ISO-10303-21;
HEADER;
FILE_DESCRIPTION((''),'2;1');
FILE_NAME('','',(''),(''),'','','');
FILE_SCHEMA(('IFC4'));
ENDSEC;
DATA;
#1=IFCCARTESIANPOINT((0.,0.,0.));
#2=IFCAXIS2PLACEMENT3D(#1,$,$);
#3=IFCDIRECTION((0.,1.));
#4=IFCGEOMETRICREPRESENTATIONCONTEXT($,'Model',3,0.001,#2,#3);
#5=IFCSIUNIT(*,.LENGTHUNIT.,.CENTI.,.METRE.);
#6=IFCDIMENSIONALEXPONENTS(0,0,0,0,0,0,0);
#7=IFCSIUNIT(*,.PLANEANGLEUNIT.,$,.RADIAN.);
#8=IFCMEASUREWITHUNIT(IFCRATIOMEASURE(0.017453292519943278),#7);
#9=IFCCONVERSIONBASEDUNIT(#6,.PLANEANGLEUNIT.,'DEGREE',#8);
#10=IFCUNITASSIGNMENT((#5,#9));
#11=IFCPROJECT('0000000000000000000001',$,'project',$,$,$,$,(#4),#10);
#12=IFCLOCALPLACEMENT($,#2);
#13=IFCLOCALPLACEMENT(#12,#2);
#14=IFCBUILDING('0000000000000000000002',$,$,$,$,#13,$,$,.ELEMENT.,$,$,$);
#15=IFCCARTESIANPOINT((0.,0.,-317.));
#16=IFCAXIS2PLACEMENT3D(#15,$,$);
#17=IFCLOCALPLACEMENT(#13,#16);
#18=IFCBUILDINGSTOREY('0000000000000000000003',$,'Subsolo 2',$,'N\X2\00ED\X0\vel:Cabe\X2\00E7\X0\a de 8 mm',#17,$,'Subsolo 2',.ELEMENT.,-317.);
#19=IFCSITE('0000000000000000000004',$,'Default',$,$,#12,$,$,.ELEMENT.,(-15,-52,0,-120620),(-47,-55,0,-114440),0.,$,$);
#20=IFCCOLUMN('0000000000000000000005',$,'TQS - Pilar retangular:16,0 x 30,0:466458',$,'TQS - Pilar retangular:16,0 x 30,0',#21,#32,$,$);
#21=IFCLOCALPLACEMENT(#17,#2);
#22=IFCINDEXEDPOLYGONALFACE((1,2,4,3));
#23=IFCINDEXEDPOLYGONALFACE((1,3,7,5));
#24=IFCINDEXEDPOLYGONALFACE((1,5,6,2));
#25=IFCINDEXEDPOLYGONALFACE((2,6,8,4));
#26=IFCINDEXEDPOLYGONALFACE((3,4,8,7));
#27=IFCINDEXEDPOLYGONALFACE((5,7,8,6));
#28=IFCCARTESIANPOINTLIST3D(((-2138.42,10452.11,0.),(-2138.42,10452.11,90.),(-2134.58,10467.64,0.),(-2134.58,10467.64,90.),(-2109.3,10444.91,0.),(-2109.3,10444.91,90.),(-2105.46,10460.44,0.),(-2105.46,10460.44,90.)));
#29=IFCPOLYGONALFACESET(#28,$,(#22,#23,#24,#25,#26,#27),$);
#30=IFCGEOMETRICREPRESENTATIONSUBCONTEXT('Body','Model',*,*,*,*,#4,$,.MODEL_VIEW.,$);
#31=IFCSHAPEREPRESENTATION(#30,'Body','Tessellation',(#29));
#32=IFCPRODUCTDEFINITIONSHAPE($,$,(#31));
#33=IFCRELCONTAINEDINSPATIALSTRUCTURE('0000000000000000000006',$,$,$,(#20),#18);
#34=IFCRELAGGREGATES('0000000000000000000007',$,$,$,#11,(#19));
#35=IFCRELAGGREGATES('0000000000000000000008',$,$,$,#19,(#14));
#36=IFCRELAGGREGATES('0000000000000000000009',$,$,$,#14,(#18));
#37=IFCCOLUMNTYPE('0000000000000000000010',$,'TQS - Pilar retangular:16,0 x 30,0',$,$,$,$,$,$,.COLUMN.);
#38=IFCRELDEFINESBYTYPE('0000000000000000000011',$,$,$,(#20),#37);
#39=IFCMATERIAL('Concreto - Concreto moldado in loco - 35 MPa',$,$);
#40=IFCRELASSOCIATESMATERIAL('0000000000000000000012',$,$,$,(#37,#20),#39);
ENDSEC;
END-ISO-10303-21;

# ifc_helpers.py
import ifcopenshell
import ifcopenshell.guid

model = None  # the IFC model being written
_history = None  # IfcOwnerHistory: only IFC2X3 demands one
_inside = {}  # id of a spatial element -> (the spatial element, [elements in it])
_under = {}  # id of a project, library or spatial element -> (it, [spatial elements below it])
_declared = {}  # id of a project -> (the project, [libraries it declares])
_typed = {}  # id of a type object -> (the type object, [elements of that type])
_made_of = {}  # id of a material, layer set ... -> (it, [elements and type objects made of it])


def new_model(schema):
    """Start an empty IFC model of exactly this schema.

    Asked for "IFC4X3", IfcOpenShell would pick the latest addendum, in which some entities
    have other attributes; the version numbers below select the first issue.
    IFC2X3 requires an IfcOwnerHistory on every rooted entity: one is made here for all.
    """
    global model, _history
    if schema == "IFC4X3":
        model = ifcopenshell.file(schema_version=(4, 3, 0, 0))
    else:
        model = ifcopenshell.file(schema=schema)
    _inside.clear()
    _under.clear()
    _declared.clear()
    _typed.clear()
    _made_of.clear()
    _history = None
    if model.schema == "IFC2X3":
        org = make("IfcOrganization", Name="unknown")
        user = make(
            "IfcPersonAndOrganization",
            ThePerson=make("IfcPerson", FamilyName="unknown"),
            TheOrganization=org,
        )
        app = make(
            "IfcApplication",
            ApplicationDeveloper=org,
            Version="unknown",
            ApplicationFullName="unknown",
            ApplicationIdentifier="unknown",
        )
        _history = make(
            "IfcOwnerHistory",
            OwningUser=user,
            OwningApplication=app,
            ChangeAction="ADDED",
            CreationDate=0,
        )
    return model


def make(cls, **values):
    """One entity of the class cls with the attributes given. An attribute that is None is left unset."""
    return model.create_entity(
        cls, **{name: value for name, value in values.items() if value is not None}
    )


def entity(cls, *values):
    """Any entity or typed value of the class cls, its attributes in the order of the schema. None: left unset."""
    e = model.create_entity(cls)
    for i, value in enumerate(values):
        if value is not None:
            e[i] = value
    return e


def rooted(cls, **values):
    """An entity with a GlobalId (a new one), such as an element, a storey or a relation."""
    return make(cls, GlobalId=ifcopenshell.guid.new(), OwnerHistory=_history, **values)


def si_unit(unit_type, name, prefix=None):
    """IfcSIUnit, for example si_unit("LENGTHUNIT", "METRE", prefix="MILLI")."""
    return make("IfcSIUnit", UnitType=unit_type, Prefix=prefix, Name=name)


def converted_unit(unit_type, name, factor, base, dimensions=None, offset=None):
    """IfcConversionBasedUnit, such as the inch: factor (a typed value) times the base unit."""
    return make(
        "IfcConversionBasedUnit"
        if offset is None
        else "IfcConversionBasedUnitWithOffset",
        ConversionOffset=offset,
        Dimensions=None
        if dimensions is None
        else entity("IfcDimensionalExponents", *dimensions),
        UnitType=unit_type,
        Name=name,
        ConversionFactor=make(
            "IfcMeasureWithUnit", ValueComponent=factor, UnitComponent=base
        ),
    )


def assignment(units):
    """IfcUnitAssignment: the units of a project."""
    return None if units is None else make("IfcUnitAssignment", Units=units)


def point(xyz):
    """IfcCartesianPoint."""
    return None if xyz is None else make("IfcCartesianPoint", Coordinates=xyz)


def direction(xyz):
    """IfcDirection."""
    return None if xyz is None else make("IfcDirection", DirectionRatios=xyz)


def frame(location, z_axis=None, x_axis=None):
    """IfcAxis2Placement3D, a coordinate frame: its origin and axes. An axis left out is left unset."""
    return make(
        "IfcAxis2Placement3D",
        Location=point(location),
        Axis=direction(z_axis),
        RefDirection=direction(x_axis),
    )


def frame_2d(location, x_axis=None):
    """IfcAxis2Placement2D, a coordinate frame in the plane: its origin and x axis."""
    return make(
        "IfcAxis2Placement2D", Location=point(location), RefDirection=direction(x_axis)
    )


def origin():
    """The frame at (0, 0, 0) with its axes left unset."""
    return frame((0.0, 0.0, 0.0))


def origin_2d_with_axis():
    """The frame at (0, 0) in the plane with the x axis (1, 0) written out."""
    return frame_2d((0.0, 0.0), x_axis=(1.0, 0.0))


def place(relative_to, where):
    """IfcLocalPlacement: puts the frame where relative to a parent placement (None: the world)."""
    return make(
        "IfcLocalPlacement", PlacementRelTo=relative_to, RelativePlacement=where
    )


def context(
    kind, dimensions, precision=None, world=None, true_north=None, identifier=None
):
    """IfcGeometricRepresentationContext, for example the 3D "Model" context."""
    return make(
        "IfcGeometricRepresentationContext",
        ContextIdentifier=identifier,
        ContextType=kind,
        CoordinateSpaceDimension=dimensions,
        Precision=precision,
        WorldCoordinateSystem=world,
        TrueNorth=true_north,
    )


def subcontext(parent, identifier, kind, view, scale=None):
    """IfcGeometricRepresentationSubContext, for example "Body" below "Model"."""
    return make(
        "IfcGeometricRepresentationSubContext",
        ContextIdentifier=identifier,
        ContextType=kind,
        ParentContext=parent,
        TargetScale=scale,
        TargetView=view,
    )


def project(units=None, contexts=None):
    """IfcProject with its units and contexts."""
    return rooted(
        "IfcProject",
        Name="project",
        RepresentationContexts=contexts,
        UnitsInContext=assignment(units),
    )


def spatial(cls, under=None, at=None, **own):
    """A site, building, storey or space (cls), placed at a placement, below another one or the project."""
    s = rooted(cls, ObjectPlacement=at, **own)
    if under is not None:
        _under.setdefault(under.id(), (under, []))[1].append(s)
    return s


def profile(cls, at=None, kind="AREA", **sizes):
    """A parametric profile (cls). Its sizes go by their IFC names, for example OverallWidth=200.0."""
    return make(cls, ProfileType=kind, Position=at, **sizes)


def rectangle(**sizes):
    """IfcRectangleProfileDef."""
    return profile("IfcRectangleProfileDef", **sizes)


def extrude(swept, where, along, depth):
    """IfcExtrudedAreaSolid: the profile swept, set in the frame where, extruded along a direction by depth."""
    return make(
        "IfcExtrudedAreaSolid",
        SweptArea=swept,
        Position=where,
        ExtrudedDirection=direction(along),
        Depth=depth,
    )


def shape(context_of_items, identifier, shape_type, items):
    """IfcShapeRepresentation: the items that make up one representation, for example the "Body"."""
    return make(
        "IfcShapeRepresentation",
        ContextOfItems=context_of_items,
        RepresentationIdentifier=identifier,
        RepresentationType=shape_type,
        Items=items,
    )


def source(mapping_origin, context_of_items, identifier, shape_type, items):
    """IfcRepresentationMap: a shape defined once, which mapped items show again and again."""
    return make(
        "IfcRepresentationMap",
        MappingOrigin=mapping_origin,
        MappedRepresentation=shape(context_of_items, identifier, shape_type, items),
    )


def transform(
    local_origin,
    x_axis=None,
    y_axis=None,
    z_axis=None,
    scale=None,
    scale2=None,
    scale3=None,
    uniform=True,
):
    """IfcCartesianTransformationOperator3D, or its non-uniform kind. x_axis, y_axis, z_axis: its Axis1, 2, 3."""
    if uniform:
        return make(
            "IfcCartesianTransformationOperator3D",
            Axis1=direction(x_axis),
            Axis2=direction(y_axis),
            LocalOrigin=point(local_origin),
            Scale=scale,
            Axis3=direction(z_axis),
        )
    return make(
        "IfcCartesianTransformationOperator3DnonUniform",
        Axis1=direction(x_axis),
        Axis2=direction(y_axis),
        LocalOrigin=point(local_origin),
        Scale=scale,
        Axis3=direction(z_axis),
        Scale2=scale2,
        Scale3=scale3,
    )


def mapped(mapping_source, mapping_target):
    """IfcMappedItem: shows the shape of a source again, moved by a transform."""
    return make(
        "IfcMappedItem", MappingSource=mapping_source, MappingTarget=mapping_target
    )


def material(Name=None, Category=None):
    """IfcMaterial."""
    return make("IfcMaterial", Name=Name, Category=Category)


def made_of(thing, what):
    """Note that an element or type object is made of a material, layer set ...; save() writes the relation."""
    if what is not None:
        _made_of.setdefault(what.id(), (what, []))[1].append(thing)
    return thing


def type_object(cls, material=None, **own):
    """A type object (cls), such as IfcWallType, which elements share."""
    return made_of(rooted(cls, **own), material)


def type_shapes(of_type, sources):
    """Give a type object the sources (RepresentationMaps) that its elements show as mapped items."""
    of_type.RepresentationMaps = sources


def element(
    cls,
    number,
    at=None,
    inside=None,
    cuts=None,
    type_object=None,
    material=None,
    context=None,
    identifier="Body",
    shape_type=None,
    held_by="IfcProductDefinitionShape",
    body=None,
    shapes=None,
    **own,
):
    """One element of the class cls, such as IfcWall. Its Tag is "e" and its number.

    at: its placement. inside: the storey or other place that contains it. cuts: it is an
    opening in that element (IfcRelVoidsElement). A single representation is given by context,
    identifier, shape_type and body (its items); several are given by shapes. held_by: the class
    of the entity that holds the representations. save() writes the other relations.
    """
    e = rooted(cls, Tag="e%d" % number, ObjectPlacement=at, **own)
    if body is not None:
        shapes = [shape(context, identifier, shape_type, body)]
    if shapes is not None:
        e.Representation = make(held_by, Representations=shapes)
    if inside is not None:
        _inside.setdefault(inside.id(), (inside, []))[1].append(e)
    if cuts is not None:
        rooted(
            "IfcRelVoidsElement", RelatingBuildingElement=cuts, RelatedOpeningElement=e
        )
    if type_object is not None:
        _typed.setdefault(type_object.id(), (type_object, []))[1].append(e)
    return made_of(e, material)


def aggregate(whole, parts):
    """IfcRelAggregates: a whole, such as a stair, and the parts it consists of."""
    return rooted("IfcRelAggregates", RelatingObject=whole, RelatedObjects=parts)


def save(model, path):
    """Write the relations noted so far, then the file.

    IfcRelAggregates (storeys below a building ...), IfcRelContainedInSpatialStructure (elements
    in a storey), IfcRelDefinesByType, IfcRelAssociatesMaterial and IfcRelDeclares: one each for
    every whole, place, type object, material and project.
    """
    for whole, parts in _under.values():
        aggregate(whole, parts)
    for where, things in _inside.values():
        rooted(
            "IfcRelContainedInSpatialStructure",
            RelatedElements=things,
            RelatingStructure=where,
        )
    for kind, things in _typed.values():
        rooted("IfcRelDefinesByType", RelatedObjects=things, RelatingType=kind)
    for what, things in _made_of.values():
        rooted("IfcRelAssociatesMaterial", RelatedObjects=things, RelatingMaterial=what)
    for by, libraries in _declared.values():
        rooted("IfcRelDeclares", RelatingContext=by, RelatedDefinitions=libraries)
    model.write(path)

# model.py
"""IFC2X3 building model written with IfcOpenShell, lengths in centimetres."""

from ifc_helpers import new_model, entity, si_unit, converted_unit, direction, frame, origin, origin_2d_with_axis, place, context, subcontext, project, spatial, rectangle, extrude, source, transform, mapped, material, type_object, type_shapes, element, save


model = new_model("IFC2X3")

# Units and contexts
model_context = context("Model", 3, precision=0.001, world=origin(), true_north=direction((0.0, 1.0)))
body_context = subcontext(model_context, "Body", "Model", "MODEL_VIEW")
ifc_project = project(units=[si_unit("LENGTHUNIT", "METRE", prefix="CENTI"), converted_unit("PLANEANGLEUNIT", "DEGREE", entity("IfcRatioMeasure", 0.017453292519943278), si_unit("PLANEANGLEUNIT", "RADIAN"), dimensions=[0, 0, 0, 0, 0, 0, 0])], contexts=[model_context])

# Site, building, storey
site_placement = place(None, origin())
site = spatial("IfcSite", under=ifc_project, at=site_placement, Name="Default", CompositionType="ELEMENT", RefLatitude=(-15, -52, 0, -120620), RefLongitude=(-47, -55, 0, -114440), RefElevation=0.0)
building_placement = place(site_placement, origin())
building = spatial("IfcBuilding", under=site, at=building_placement, CompositionType="ELEMENT")
storey_placement = place(building_placement, frame((0.0, 0.0, -317.0)))
storey = spatial("IfcBuildingStorey", under=building, at=storey_placement, Name="Subsolo 2", ObjectType="Nível:Cabeça de 8 mm", LongName="Subsolo 2", CompositionType="ELEMENT", Elevation=-317.0)

# Column
ifc_material = material(Name="Concreto - Concreto moldado in loco - 35 MPa")
column_type_1 = type_object("IfcColumnType", Name="TQS - Pilar retangular:16,0 x 30,0", PredefinedType="COLUMN", material=ifc_material)
shared_shape_1 = source(origin(), body_context, "Body", "SweptSolid", [
    extrude(rectangle(XDim=30.0, YDim=16.0, at=origin_2d_with_axis()), frame((-2121.94, 10456.27, -317.0), z_axis=(0.0, 0.0, 1.0), x_axis=(-0.970743, 0.240122, 0.0)), (0.0, 0.0, 1.0), 90.0),
])
type_shapes(column_type_1, [shared_shape_1])
column_1_placement = place(storey_placement, frame((0.0, 0.0, 317.0)))
element("IfcColumn", 1, at=column_1_placement, inside=storey, type_object=column_type_1, material=ifc_material, Name="TQS - Pilar retangular:16,0 x 30,0:466458", ObjectType="TQS - Pilar retangular:16,0 x 30,0", context=body_context, shape_type="MappedRepresentation", body=[
    mapped(shared_shape_1, transform((0.0, 0.0, 0.0), scale=1.0)),
])

save(model, "model.ifc")
